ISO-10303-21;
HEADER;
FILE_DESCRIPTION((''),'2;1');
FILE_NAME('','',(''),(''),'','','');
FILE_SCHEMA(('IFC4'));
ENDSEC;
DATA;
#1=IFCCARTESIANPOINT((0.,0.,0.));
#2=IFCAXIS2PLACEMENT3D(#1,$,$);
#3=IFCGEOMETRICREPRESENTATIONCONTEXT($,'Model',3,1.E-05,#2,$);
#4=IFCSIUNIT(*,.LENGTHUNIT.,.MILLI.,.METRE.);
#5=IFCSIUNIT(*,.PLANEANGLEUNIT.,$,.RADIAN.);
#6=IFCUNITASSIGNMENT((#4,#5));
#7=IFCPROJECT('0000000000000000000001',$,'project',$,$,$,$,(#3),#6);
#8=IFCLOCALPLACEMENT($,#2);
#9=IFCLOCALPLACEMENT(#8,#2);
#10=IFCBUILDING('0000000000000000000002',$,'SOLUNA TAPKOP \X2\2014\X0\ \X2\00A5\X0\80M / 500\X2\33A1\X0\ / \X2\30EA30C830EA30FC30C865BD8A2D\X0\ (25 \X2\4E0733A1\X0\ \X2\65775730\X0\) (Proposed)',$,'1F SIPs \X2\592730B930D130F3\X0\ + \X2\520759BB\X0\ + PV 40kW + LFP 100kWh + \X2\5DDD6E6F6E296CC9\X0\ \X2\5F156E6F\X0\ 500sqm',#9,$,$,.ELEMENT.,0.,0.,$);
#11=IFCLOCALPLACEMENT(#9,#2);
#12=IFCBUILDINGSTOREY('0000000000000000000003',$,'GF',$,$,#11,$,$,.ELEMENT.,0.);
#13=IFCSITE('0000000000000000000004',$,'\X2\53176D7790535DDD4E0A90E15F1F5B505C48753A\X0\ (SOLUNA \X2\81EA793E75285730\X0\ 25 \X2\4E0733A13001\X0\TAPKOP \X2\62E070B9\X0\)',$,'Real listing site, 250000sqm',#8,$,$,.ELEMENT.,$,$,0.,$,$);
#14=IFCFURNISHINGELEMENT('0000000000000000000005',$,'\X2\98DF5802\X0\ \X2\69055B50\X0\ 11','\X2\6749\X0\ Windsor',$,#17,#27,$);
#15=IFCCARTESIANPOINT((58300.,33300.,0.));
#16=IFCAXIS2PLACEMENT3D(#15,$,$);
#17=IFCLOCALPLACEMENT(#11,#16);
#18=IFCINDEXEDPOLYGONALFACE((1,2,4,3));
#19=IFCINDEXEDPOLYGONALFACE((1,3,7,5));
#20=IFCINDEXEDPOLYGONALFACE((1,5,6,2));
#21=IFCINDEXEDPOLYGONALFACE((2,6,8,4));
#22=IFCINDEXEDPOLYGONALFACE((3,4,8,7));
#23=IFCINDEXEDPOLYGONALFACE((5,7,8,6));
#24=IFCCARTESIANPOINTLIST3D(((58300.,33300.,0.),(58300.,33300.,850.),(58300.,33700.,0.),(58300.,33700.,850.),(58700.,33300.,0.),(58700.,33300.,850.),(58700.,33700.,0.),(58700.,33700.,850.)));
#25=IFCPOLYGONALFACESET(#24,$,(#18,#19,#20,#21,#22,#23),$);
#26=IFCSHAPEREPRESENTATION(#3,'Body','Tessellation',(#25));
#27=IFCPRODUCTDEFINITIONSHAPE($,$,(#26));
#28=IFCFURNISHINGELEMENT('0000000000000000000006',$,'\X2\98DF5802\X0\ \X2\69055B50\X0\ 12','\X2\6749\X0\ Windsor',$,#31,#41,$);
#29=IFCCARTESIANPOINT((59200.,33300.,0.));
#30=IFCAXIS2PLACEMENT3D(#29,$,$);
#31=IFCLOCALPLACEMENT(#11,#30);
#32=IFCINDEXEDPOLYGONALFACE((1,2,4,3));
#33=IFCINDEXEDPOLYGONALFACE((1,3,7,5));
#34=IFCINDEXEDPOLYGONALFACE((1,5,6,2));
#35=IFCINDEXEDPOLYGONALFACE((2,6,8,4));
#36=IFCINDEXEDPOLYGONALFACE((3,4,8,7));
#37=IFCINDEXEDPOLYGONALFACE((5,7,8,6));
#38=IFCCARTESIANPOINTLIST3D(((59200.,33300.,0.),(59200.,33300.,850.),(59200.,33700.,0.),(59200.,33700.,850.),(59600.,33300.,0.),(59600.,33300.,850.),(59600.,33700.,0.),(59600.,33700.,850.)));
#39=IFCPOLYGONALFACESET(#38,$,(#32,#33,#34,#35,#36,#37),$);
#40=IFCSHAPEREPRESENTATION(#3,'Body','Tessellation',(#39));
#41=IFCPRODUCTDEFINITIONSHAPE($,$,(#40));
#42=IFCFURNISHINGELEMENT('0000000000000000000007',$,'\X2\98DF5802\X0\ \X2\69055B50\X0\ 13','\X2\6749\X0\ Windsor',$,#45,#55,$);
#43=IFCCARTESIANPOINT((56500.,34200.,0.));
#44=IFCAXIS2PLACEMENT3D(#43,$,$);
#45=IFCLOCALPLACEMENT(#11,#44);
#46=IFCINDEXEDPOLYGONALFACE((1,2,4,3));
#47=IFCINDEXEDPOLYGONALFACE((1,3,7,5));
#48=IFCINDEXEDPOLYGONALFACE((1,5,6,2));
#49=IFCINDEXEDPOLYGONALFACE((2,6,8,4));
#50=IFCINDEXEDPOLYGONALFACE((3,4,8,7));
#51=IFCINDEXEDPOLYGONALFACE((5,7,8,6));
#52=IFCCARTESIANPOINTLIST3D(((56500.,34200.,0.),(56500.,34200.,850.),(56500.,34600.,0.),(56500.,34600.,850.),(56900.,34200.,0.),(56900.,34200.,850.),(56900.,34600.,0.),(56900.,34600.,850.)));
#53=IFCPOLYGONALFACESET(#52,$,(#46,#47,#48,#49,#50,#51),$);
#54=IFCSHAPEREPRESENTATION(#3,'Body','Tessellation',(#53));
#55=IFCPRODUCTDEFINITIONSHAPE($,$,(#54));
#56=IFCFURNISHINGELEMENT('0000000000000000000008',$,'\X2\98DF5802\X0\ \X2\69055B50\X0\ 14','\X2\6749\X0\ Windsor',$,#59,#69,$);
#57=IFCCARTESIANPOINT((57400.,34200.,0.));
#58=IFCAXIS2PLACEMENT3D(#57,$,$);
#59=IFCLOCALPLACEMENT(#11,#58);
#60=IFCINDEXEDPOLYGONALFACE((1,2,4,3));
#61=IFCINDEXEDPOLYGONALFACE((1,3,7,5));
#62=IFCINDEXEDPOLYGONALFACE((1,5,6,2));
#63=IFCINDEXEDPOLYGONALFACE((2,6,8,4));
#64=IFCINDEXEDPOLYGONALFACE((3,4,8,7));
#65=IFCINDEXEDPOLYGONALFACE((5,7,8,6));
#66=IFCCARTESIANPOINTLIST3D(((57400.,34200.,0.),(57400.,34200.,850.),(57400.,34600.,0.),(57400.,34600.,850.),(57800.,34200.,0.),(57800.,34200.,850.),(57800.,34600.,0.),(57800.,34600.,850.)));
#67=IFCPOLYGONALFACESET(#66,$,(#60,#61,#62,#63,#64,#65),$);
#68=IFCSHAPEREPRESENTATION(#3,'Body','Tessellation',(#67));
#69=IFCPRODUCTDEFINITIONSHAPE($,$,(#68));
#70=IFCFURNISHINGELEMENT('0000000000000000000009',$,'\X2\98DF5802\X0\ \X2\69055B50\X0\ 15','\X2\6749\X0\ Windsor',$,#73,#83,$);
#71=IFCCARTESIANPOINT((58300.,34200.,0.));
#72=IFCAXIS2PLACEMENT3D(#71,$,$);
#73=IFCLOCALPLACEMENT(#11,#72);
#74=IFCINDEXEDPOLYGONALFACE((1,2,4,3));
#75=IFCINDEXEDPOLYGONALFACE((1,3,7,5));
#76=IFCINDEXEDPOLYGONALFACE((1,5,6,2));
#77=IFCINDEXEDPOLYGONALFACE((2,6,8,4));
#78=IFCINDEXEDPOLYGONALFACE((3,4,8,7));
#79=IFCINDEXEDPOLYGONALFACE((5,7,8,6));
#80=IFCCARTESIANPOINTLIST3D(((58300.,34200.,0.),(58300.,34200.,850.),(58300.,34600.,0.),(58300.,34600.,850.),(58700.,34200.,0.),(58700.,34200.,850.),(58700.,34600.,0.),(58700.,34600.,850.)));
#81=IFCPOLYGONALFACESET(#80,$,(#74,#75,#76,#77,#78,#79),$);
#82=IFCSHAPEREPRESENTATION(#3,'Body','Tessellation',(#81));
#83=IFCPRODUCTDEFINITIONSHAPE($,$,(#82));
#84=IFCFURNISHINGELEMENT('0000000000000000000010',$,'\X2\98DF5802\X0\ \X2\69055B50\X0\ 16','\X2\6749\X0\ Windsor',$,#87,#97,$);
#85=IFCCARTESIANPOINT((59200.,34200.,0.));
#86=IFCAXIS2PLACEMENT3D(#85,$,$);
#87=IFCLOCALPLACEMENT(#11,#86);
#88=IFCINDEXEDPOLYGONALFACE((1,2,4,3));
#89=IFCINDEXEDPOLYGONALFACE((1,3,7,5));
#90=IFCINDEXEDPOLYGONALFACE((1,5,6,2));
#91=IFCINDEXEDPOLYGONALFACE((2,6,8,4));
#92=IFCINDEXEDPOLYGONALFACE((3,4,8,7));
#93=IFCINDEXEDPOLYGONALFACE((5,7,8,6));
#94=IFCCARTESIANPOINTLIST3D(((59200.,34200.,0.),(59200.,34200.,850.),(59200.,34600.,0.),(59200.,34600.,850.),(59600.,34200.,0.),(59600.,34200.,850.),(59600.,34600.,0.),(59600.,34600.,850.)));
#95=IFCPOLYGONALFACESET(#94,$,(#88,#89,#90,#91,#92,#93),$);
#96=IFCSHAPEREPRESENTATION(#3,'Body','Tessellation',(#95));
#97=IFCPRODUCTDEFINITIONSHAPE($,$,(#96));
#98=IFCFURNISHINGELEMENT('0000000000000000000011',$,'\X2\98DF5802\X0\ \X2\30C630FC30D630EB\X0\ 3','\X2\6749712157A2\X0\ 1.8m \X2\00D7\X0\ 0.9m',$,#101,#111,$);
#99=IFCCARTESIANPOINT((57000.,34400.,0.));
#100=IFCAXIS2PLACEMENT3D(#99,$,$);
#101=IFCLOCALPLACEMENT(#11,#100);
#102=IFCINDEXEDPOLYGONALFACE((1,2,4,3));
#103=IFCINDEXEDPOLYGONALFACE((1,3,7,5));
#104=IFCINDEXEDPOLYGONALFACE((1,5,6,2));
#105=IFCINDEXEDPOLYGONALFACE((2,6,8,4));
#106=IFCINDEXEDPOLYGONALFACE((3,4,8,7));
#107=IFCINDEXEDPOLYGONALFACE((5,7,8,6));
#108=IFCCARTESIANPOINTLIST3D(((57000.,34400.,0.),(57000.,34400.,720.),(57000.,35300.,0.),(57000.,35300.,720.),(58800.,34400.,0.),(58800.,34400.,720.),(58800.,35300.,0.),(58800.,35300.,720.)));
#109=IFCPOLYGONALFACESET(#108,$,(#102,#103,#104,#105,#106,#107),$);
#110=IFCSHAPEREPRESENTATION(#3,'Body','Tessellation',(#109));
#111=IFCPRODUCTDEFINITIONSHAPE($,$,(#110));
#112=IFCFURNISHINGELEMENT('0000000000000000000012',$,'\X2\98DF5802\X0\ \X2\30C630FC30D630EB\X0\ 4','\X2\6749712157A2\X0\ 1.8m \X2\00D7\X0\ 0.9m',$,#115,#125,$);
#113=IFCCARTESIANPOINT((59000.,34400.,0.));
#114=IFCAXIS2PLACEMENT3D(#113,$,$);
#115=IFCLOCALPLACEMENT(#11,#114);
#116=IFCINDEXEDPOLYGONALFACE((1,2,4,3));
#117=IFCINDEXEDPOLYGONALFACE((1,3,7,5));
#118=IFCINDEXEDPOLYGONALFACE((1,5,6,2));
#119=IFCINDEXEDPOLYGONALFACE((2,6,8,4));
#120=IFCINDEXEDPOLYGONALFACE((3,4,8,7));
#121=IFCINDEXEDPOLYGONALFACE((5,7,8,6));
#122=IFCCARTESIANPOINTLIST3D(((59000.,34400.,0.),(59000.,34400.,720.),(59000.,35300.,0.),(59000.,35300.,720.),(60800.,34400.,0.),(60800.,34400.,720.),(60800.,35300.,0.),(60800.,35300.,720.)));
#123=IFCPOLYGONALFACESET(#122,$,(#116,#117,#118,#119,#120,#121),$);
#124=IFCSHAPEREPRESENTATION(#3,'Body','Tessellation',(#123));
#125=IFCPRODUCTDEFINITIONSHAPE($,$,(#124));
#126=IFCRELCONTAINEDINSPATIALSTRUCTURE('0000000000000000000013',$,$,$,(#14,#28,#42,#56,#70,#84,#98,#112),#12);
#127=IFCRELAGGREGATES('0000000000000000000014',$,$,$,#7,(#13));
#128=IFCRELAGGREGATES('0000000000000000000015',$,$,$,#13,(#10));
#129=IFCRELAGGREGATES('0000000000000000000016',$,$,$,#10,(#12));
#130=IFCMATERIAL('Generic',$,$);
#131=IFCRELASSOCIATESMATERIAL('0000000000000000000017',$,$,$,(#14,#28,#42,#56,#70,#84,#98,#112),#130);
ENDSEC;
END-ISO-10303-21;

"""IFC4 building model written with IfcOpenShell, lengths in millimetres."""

from ifc_helpers import new_model, si_unit, frame, frame_2d, origin, place, context, project, spatial, rectangle, extrude, material, element, save


model = new_model("IFC4")

# Units and contexts
model_context = context("Model", 3, precision=1e-05, world=origin())
ifc_project = project(units=[si_unit("LENGTHUNIT", "METRE", prefix="MILLI"), si_unit("PLANEANGLEUNIT", "RADIAN")], contexts=[model_context])

# Site, building, storey
site_placement = place(None, origin())
site = spatial("IfcSite", under=ifc_project, at=site_placement, Name="北海道川上郡弟子屈町 (SOLUNA 自社用地 25 万㎡、TAPKOP 拠点)", ObjectType="Real listing site, 250000sqm", CompositionType="ELEMENT", RefElevation=0.0)
building_placement = place(site_placement, origin())
building = spatial("IfcBuilding", under=site, at=building_placement, Name="SOLUNA TAPKOP — ¥80M / 500㎡ / リトリート施設 (25 万㎡ 敷地) (Proposed)", ObjectType="1F SIPs 大スパン + 切妻 + PV 40kW + LFP 100kWh + 川湯温泉 引湯 500sqm", CompositionType="ELEMENT", ElevationOfRefHeight=0.0, ElevationOfTerrain=0.0)
storey_placement = place(building_placement, origin())
storey = spatial("IfcBuildingStorey", under=building, at=storey_placement, Name="GF", CompositionType="ELEMENT", Elevation=0.0)

# Shared definitions
ifc_material = material(Name="Generic")

# Furnishing elements
furnishing_1_placement = place(storey_placement, frame((58300.0, 33300.0, 0.0)))
element("IfcFurnishingElement", 1, at=furnishing_1_placement, inside=storey, material=ifc_material, Name="食堂 椅子 11", Description="杉 Windsor", context=model_context, shape_type="SweptSolid", body=[
    extrude(rectangle(XDim=400.0, YDim=400.0, at=frame_2d((200.0, 200.0))), frame((58300.0, 33300.0, 0.0)), (0.0, 0.0, 1.0), 850.0),
])
furnishing_2_placement = place(storey_placement, frame((59200.0, 33300.0, 0.0)))
element("IfcFurnishingElement", 2, at=furnishing_2_placement, inside=storey, material=ifc_material, Name="食堂 椅子 12", Description="杉 Windsor", context=model_context, shape_type="SweptSolid", body=[
    extrude(rectangle(XDim=400.0, YDim=400.0, at=frame_2d((200.0, 200.0))), frame((59200.0, 33300.0, 0.0)), (0.0, 0.0, 1.0), 850.0),
])
furnishing_3_placement = place(storey_placement, frame((56500.0, 34200.0, 0.0)))
element("IfcFurnishingElement", 3, at=furnishing_3_placement, inside=storey, material=ifc_material, Name="食堂 椅子 13", Description="杉 Windsor", context=model_context, shape_type="SweptSolid", body=[
    extrude(rectangle(XDim=400.0, YDim=400.0, at=frame_2d((200.0, 200.0))), frame((56500.0, 34200.0, 0.0)), (0.0, 0.0, 1.0), 850.0),
])
furnishing_4_placement = place(storey_placement, frame((57400.0, 34200.0, 0.0)))
element("IfcFurnishingElement", 4, at=furnishing_4_placement, inside=storey, material=ifc_material, Name="食堂 椅子 14", Description="杉 Windsor", context=model_context, shape_type="SweptSolid", body=[
    extrude(rectangle(XDim=400.0, YDim=400.0, at=frame_2d((200.0, 200.0))), frame((57400.0, 34200.0, 0.0)), (0.0, 0.0, 1.0), 850.0),
])
furnishing_5_placement = place(storey_placement, frame((58300.0, 34200.0, 0.0)))
element("IfcFurnishingElement", 5, at=furnishing_5_placement, inside=storey, material=ifc_material, Name="食堂 椅子 15", Description="杉 Windsor", context=model_context, shape_type="SweptSolid", body=[
    extrude(rectangle(XDim=400.0, YDim=400.0, at=frame_2d((200.0, 200.0))), frame((58300.0, 34200.0, 0.0)), (0.0, 0.0, 1.0), 850.0),
])
furnishing_6_placement = place(storey_placement, frame((59200.0, 34200.0, 0.0)))
element("IfcFurnishingElement", 6, at=furnishing_6_placement, inside=storey, material=ifc_material, Name="食堂 椅子 16", Description="杉 Windsor", context=model_context, shape_type="SweptSolid", body=[
    extrude(rectangle(XDim=400.0, YDim=400.0, at=frame_2d((200.0, 200.0))), frame((59200.0, 34200.0, 0.0)), (0.0, 0.0, 1.0), 850.0),
])
furnishing_7_placement = place(storey_placement, frame((57000.0, 34400.0, 0.0)))
element("IfcFurnishingElement", 7, at=furnishing_7_placement, inside=storey, material=ifc_material, Name="食堂 テーブル 3", Description="杉無垢 1.8m × 0.9m", context=model_context, shape_type="SweptSolid", body=[
    extrude(rectangle(XDim=1800.0, YDim=900.0, at=frame_2d((900.0, 450.0))), frame((57000.0, 34400.0, 0.0)), (0.0, 0.0, 1.0), 720.0),
])
furnishing_8_placement = place(storey_placement, frame((59000.0, 34400.0, 0.0)))
element("IfcFurnishingElement", 8, at=furnishing_8_placement, inside=storey, material=ifc_material, Name="食堂 テーブル 4", Description="杉無垢 1.8m × 0.9m", context=model_context, shape_type="SweptSolid", body=[
    extrude(rectangle(XDim=1800.0, YDim=900.0, at=frame_2d((900.0, 450.0))), frame((59000.0, 34400.0, 0.0)), (0.0, 0.0, 1.0), 720.0),
])

save(model, "model.ifc")
